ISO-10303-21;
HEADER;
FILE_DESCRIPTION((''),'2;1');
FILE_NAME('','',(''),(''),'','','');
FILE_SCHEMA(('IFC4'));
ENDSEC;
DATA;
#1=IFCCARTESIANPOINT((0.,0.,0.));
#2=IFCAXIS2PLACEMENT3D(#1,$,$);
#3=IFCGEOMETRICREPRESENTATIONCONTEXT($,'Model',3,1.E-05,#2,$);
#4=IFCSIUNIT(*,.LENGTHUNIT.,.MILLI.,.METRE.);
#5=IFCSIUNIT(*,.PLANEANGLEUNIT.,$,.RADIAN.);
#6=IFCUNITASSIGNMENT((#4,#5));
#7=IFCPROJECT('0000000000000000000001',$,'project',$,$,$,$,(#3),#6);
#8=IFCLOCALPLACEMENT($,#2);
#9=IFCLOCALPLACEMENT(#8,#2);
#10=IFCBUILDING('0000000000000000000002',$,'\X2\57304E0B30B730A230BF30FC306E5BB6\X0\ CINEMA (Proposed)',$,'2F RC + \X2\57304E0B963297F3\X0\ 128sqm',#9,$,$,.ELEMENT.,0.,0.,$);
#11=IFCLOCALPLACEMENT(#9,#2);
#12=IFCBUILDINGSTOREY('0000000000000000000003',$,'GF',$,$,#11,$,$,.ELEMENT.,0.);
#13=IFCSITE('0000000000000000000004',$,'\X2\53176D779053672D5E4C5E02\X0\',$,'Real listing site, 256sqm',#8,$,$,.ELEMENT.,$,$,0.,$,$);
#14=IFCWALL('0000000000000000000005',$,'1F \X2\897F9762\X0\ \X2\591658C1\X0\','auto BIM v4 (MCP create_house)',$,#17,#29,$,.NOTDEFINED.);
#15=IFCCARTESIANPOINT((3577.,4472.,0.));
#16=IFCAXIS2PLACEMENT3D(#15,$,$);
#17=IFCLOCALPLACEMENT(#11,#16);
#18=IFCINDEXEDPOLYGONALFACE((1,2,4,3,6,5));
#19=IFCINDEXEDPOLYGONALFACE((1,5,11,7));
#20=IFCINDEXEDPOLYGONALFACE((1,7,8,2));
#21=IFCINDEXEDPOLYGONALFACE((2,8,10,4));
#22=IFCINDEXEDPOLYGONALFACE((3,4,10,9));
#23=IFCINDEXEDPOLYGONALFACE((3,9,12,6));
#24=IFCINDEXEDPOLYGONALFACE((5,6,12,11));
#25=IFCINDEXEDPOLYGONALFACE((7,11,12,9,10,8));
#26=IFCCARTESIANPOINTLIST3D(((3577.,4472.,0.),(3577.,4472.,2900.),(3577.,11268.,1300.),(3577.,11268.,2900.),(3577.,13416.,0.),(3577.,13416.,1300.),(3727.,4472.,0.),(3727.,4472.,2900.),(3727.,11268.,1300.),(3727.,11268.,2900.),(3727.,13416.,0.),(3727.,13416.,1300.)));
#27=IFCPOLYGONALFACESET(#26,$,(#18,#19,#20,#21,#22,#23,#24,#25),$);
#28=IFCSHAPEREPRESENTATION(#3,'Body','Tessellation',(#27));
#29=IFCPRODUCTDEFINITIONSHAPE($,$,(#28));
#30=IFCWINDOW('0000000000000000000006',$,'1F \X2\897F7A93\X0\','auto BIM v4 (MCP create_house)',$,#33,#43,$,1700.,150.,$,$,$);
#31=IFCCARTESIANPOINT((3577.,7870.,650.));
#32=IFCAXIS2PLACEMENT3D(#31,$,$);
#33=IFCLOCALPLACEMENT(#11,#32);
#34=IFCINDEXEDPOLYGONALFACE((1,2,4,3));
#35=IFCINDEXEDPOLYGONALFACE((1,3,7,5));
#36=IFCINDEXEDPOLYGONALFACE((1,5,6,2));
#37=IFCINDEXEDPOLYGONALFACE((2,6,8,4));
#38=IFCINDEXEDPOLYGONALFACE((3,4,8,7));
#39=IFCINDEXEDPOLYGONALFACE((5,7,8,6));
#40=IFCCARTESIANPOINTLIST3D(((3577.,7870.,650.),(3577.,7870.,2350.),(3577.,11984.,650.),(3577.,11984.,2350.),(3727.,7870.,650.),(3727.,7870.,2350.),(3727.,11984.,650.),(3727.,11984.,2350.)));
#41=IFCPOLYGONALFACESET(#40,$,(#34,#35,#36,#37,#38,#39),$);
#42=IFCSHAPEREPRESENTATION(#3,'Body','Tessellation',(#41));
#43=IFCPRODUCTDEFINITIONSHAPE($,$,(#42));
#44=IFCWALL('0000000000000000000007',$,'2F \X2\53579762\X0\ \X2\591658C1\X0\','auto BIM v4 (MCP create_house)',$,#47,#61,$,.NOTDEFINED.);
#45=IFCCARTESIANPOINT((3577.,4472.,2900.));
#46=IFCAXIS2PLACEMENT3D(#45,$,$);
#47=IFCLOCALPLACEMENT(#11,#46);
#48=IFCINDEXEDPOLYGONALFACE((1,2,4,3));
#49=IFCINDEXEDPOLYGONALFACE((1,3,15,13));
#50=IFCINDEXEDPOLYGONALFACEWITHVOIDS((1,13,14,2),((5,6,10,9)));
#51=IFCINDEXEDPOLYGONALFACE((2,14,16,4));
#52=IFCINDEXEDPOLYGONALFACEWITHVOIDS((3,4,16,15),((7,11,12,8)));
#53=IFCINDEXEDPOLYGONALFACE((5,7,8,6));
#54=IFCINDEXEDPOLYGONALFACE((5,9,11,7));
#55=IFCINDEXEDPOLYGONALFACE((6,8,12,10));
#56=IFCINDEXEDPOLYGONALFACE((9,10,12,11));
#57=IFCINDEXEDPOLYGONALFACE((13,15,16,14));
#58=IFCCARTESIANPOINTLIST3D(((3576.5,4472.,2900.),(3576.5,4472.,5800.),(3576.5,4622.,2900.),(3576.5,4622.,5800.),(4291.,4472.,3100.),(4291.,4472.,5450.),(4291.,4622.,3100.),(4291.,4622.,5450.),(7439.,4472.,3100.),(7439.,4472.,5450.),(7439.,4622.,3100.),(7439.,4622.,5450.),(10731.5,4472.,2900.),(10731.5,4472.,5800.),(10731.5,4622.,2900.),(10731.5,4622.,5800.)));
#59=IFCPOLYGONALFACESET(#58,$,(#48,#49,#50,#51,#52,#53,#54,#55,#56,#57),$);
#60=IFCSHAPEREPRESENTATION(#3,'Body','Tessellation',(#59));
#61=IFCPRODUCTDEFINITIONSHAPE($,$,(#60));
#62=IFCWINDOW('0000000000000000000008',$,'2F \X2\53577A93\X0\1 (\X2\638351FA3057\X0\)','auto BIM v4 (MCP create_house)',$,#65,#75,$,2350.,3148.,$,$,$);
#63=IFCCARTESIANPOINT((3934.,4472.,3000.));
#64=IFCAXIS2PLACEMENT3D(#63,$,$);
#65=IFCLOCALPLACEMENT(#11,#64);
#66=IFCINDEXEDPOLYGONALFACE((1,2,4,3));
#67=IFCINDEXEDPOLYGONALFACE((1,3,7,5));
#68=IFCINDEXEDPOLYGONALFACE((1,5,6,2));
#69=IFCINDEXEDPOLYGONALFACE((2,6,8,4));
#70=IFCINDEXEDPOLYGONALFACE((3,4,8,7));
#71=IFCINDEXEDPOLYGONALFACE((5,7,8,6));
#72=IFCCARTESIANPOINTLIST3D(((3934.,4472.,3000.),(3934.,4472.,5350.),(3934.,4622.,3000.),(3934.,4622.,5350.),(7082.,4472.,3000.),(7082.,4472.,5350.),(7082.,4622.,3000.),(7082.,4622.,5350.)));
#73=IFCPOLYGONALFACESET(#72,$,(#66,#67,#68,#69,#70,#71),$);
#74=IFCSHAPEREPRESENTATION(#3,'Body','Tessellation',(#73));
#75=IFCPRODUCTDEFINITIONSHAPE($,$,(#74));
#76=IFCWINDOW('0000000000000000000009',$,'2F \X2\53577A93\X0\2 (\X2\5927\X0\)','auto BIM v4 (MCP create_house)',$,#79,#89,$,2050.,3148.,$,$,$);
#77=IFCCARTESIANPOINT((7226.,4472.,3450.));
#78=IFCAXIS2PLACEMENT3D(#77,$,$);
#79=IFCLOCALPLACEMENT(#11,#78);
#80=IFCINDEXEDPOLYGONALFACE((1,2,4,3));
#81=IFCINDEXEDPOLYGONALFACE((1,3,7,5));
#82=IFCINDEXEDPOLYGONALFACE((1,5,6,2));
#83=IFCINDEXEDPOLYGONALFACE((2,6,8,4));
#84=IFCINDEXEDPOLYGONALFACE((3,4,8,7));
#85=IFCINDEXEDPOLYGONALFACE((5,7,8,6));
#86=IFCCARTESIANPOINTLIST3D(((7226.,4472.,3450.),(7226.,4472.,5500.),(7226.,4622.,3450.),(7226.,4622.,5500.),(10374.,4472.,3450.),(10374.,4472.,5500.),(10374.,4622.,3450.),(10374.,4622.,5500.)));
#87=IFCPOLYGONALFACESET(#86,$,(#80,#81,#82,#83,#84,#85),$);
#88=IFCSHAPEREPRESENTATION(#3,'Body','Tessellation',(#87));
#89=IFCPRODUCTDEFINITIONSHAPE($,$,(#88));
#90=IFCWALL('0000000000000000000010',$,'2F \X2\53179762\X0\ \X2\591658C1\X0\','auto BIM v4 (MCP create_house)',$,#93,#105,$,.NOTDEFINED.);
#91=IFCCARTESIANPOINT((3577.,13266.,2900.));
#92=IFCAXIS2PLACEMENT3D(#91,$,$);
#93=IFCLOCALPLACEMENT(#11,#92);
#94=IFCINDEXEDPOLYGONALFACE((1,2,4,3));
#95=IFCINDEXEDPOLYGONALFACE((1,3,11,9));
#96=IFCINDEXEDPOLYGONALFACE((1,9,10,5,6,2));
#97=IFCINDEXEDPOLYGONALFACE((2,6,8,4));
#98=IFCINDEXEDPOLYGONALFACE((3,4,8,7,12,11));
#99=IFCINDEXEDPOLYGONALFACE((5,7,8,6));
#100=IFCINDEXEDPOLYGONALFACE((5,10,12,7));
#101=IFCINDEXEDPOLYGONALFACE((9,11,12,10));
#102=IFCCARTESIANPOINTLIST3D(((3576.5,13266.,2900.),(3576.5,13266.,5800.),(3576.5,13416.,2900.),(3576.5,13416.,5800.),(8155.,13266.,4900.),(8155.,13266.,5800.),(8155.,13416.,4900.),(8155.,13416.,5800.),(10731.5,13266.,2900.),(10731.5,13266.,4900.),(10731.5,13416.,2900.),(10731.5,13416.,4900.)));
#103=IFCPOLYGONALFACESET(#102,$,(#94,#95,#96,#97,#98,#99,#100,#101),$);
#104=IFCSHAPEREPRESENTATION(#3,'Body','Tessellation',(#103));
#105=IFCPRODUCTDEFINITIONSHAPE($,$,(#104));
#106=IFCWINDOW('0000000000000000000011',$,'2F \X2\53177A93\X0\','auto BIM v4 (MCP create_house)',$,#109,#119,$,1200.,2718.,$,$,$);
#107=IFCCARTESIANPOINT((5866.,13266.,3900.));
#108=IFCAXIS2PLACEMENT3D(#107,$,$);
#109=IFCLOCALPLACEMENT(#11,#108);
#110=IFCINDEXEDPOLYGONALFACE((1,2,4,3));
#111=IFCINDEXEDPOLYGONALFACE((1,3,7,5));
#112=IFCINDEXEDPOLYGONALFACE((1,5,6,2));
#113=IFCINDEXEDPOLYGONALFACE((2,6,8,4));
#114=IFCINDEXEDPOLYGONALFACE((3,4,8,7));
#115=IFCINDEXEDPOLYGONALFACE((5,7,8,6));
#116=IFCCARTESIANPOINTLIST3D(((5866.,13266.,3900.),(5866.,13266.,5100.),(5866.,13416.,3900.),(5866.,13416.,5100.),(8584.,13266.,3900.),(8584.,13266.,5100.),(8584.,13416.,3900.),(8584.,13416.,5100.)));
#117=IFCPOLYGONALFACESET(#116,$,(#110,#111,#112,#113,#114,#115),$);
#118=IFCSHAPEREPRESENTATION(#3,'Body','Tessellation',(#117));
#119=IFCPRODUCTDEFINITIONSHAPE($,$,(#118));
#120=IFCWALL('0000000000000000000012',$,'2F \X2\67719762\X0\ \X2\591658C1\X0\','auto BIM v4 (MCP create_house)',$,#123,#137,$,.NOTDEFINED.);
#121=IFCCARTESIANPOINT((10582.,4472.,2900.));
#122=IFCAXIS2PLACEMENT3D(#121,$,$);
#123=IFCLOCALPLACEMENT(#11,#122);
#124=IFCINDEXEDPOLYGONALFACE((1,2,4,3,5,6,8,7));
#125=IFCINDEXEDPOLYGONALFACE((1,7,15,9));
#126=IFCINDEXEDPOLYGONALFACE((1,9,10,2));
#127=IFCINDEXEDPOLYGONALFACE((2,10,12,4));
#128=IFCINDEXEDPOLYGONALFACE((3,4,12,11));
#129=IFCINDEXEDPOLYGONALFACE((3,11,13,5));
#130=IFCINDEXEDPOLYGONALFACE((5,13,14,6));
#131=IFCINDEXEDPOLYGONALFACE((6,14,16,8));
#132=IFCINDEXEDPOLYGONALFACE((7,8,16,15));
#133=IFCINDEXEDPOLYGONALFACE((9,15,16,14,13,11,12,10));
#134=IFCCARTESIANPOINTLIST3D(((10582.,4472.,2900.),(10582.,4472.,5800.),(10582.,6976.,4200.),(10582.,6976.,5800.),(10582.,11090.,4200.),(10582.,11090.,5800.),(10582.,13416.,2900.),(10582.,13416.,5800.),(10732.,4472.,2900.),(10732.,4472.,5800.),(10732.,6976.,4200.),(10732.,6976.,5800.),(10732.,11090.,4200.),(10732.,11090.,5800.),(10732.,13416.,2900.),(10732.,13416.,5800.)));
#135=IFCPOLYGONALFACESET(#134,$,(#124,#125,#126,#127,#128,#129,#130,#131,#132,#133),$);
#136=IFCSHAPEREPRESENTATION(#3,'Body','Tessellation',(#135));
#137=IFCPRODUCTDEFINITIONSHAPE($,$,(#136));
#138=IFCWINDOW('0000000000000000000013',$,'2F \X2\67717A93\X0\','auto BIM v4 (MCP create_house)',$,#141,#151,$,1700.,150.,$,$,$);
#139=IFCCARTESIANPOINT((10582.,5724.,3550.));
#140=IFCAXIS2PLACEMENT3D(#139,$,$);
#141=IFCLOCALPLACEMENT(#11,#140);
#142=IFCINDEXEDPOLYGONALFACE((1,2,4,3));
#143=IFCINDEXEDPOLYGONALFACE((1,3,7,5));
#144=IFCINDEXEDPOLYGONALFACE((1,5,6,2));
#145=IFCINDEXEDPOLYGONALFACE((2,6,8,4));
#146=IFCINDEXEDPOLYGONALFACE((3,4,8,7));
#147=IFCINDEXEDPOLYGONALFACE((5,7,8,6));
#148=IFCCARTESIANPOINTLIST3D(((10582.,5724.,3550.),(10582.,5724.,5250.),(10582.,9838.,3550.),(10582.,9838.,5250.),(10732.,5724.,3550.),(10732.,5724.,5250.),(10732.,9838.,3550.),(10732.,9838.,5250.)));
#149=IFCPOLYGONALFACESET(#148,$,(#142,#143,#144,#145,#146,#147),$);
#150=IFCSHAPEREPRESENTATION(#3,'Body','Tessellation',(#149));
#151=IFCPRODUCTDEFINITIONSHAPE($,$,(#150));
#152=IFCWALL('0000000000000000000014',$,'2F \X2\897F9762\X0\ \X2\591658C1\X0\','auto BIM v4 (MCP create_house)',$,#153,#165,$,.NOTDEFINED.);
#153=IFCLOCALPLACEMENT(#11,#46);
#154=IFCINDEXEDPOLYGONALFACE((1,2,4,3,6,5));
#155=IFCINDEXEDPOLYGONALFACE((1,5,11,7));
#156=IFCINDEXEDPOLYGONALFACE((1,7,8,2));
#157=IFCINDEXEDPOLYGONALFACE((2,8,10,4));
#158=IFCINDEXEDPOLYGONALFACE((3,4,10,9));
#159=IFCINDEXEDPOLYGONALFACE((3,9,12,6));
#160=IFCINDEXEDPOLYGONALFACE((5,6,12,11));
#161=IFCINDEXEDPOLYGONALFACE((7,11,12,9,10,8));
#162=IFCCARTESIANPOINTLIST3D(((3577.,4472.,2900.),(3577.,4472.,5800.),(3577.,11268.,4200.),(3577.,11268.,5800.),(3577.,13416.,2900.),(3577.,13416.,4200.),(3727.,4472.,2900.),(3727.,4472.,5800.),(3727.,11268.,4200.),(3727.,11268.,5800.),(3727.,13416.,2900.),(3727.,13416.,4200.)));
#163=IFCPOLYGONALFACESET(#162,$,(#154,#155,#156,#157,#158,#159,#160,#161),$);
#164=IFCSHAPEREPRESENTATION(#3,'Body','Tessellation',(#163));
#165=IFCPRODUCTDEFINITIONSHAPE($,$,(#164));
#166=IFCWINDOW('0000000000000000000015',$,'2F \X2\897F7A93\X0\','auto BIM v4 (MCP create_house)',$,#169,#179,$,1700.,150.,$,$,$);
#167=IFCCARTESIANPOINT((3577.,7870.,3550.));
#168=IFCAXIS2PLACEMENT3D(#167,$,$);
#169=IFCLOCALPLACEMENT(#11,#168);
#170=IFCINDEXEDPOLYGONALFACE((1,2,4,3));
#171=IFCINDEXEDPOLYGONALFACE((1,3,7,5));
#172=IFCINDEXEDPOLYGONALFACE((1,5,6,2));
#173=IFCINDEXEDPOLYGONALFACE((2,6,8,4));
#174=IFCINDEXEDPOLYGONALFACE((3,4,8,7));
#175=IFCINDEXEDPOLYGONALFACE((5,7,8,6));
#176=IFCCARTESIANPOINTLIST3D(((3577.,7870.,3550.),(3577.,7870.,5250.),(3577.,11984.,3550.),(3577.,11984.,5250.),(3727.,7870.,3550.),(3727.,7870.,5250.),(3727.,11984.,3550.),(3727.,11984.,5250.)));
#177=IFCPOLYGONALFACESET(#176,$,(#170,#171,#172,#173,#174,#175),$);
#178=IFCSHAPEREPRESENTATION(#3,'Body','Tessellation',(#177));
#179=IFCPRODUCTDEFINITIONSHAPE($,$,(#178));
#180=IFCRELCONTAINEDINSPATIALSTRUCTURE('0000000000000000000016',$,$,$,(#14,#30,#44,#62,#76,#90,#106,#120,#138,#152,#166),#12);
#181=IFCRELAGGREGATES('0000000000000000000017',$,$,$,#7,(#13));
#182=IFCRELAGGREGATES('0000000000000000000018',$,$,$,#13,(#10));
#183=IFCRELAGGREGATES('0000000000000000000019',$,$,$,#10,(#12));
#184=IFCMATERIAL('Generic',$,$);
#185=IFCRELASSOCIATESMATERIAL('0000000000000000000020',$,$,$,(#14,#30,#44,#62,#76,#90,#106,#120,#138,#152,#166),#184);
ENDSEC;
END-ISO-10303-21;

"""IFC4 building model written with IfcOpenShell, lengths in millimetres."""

from ifc_helpers import new_model, si_unit, frame, frame_2d, origin, place, context, project, spatial, rectangle, extrude, material, element, fill, save


model = new_model("IFC4")

# Units and contexts
model_context = context("Model", 3, precision=1e-05, world=origin())
ifc_project = project(units=[si_unit("LENGTHUNIT", "METRE", prefix="MILLI"), si_unit("PLANEANGLEUNIT", "RADIAN")], contexts=[model_context])

# Site, building, storey
site_placement = place(None, origin())
site = spatial("IfcSite", under=ifc_project, at=site_placement, Name="北海道札幌市", ObjectType="Real listing site, 256sqm", CompositionType="ELEMENT", RefElevation=0.0)
building_placement = place(site_placement, origin())
building = spatial("IfcBuilding", under=site, at=building_placement, Name="地下シアターの家 CINEMA (Proposed)", ObjectType="2F RC + 地下防音 128sqm", CompositionType="ELEMENT", ElevationOfRefHeight=0.0, ElevationOfTerrain=0.0)
storey_placement = place(building_placement, origin())
storey = spatial("IfcBuildingStorey", under=building, at=storey_placement, Name="GF", CompositionType="ELEMENT", Elevation=0.0)

# Shared definitions
ifc_material = material(Name="Generic")

# Wall, opening, window
wall_1_placement = place(storey_placement, frame((3577.0, 4472.0, 0.0)))
wall_1 = element("IfcWall", 1, at=wall_1_placement, inside=storey, material=ifc_material, Name="1F 西面 外壁", Description="auto BIM v4 (MCP create_house)", PredefinedType="NOTDEFINED", context=model_context, shape_type="SweptSolid", body=[
    extrude(rectangle(XDim=150.0, YDim=8944.0, at=frame_2d((75.0, 4472.0))), frame((3577.0, 4472.0, 0.0)), (0.0, 0.0, 1.0), 2900.0),
])
opening_1_placement = place(storey_placement, frame((3577.0, 7870.0, 650.0)))
opening_1 = element("IfcOpeningElement", 2, at=opening_1_placement, cuts=wall_1, PredefinedType="NOTDEFINED", context=model_context, shape_type="SweptSolid", body=[
    extrude(rectangle(XDim=150.0, YDim=4114.0, at=frame_2d((75.0, 2057.0))), frame((3577.0, 7870.0, 650.0)), (0.0, 0.0, 1.0), 1700.0),
])
window_1_placement = place(storey_placement, frame((3577.0, 7870.0, 650.0)))
window_1 = element("IfcWindow", 3, at=window_1_placement, inside=storey, material=ifc_material, Name="1F 西窓", Description="auto BIM v4 (MCP create_house)", OverallHeight=1700.0, OverallWidth=150.0, context=model_context, shape_type="SweptSolid", body=[
    extrude(rectangle(XDim=150.0, YDim=4114.0, at=frame_2d((75.0, 2057.0))), frame((3577.0, 7870.0, 650.0)), (0.0, 0.0, 1.0), 1700.0),
])
fill(opening_1, window_1)

# Wall, openings, windows
wall_2_placement = place(storey_placement, frame((3577.0, 4472.0, 2900.0)))
wall_2 = element("IfcWall", 4, at=wall_2_placement, inside=storey, material=ifc_material, Name="2F 南面 外壁", Description="auto BIM v4 (MCP create_house)", PredefinedType="NOTDEFINED", context=model_context, shape_type="SweptSolid", body=[
    extrude(rectangle(XDim=7155.0, YDim=150.0, at=frame_2d((3577.0, 75.0))), frame((3577.0, 4472.0, 2900.0)), (0.0, 0.0, 1.0), 2900.0),
])
opening_2_placement = place(storey_placement, frame((3934.0, 4472.0, 3000.0)))
opening_2 = element("IfcOpeningElement", 5, at=opening_2_placement, cuts=wall_2, PredefinedType="NOTDEFINED", context=model_context, shape_type="SweptSolid", body=[
    extrude(rectangle(XDim=3148.0, YDim=150.0, at=frame_2d((1574.0, 75.0))), frame((3934.0, 4472.0, 3000.0)), (0.0, 0.0, 1.0), 2350.0),
])
opening_3_placement = place(storey_placement, frame((7226.0, 4472.0, 3450.0)))
opening_3 = element("IfcOpeningElement", 6, at=opening_3_placement, cuts=wall_2, PredefinedType="NOTDEFINED", context=model_context, shape_type="SweptSolid", body=[
    extrude(rectangle(XDim=3148.0, YDim=150.0, at=frame_2d((1574.0, 75.0))), frame((7226.0, 4472.0, 3450.0)), (0.0, 0.0, 1.0), 2050.0),
])
window_2_placement = place(storey_placement, frame((3934.0, 4472.0, 3000.0)))
window_2 = element("IfcWindow", 7, at=window_2_placement, inside=storey, material=ifc_material, Name="2F 南窓1 (掃出し)", Description="auto BIM v4 (MCP create_house)", OverallHeight=2350.0, OverallWidth=3148.0, context=model_context, shape_type="SweptSolid", body=[
    extrude(rectangle(XDim=3148.0, YDim=150.0, at=frame_2d((1574.0, 75.0))), frame((3934.0, 4472.0, 3000.0)), (0.0, 0.0, 1.0), 2350.0),
])
fill(opening_2, window_2)
window_3_placement = place(storey_placement, frame((7226.0, 4472.0, 3450.0)))
window_3 = element("IfcWindow", 8, at=window_3_placement, inside=storey, material=ifc_material, Name="2F 南窓2 (大)", Description="auto BIM v4 (MCP create_house)", OverallHeight=2050.0, OverallWidth=3148.0, context=model_context, shape_type="SweptSolid", body=[
    extrude(rectangle(XDim=3148.0, YDim=150.0, at=frame_2d((1574.0, 75.0))), frame((7226.0, 4472.0, 3450.0)), (0.0, 0.0, 1.0), 2050.0),
])
fill(opening_3, window_3)

# Walls, openings, windows
wall_3_placement = place(storey_placement, frame((3577.0, 13266.0, 2900.0)))
wall_3 = element("IfcWall", 9, at=wall_3_placement, inside=storey, material=ifc_material, Name="2F 北面 外壁", Description="auto BIM v4 (MCP create_house)", PredefinedType="NOTDEFINED", context=model_context, shape_type="SweptSolid", body=[
    extrude(rectangle(XDim=7155.0, YDim=150.0, at=frame_2d((3577.0, 75.0))), frame((3577.0, 13266.0, 2900.0)), (0.0, 0.0, 1.0), 2900.0),
])
opening_4_placement = place(storey_placement, frame((5866.0, 13266.0, 3900.0)))
opening_4 = element("IfcOpeningElement", 10, at=opening_4_placement, cuts=wall_3, PredefinedType="NOTDEFINED", context=model_context, shape_type="SweptSolid", body=[
    extrude(rectangle(XDim=2718.0, YDim=150.0, at=frame_2d((1359.0, 75.0))), frame((5866.0, 13266.0, 3900.0)), (0.0, 0.0, 1.0), 1200.0),
])
window_4_placement = place(storey_placement, frame((5866.0, 13266.0, 3900.0)))
window_4 = element("IfcWindow", 11, at=window_4_placement, inside=storey, material=ifc_material, Name="2F 北窓", Description="auto BIM v4 (MCP create_house)", OverallHeight=1200.0, OverallWidth=2718.0, context=model_context, shape_type="SweptSolid", body=[
    extrude(rectangle(XDim=2718.0, YDim=150.0, at=frame_2d((1359.0, 75.0))), frame((5866.0, 13266.0, 3900.0)), (0.0, 0.0, 1.0), 1200.0),
])
fill(opening_4, window_4)
wall_4_placement = place(storey_placement, frame((10582.0, 4472.0, 2900.0)))
wall_4 = element("IfcWall", 12, at=wall_4_placement, inside=storey, material=ifc_material, Name="2F 東面 外壁", Description="auto BIM v4 (MCP create_house)", PredefinedType="NOTDEFINED", context=model_context, shape_type="SweptSolid", body=[
    extrude(rectangle(XDim=150.0, YDim=8944.0, at=frame_2d((75.0, 4472.0))), frame((10582.0, 4472.0, 2900.0)), (0.0, 0.0, 1.0), 2900.0),
])
opening_5_placement = place(storey_placement, frame((10582.0, 5724.0, 3550.0)))
opening_5 = element("IfcOpeningElement", 13, at=opening_5_placement, cuts=wall_4, PredefinedType="NOTDEFINED", context=model_context, shape_type="SweptSolid", body=[
    extrude(rectangle(XDim=150.0, YDim=4114.0, at=frame_2d((75.0, 2057.0))), frame((10582.0, 5724.0, 3550.0)), (0.0, 0.0, 1.0), 1700.0),
])
window_5_placement = place(storey_placement, frame((10582.0, 5724.0, 3550.0)))
window_5 = element("IfcWindow", 14, at=window_5_placement, inside=storey, material=ifc_material, Name="2F 東窓", Description="auto BIM v4 (MCP create_house)", OverallHeight=1700.0, OverallWidth=150.0, context=model_context, shape_type="SweptSolid", body=[
    extrude(rectangle(XDim=150.0, YDim=4114.0, at=frame_2d((75.0, 2057.0))), frame((10582.0, 5724.0, 3550.0)), (0.0, 0.0, 1.0), 1700.0),
])
fill(opening_5, window_5)
wall_5_placement = place(storey_placement, frame((3577.0, 4472.0, 2900.0)))
wall_5 = element("IfcWall", 15, at=wall_5_placement, inside=storey, material=ifc_material, Name="2F 西面 外壁", Description="auto BIM v4 (MCP create_house)", PredefinedType="NOTDEFINED", context=model_context, shape_type="SweptSolid", body=[
    extrude(rectangle(XDim=150.0, YDim=8944.0, at=frame_2d((75.0, 4472.0))), frame((3577.0, 4472.0, 2900.0)), (0.0, 0.0, 1.0), 2900.0),
])
opening_6_placement = place(storey_placement, frame((3577.0, 7870.0, 3550.0)))
opening_6 = element("IfcOpeningElement", 16, at=opening_6_placement, cuts=wall_5, PredefinedType="NOTDEFINED", context=model_context, shape_type="SweptSolid", body=[
    extrude(rectangle(XDim=150.0, YDim=4114.0, at=frame_2d((75.0, 2057.0))), frame((3577.0, 7870.0, 3550.0)), (0.0, 0.0, 1.0), 1700.0),
])
window_6_placement = place(storey_placement, frame((3577.0, 7870.0, 3550.0)))
window_6 = element("IfcWindow", 17, at=window_6_placement, inside=storey, material=ifc_material, Name="2F 西窓", Description="auto BIM v4 (MCP create_house)", OverallHeight=1700.0, OverallWidth=150.0, context=model_context, shape_type="SweptSolid", body=[
    extrude(rectangle(XDim=150.0, YDim=4114.0, at=frame_2d((75.0, 2057.0))), frame((3577.0, 7870.0, 3550.0)), (0.0, 0.0, 1.0), 1700.0),
])
fill(opening_6, window_6)

save(model, "model.ifc")
